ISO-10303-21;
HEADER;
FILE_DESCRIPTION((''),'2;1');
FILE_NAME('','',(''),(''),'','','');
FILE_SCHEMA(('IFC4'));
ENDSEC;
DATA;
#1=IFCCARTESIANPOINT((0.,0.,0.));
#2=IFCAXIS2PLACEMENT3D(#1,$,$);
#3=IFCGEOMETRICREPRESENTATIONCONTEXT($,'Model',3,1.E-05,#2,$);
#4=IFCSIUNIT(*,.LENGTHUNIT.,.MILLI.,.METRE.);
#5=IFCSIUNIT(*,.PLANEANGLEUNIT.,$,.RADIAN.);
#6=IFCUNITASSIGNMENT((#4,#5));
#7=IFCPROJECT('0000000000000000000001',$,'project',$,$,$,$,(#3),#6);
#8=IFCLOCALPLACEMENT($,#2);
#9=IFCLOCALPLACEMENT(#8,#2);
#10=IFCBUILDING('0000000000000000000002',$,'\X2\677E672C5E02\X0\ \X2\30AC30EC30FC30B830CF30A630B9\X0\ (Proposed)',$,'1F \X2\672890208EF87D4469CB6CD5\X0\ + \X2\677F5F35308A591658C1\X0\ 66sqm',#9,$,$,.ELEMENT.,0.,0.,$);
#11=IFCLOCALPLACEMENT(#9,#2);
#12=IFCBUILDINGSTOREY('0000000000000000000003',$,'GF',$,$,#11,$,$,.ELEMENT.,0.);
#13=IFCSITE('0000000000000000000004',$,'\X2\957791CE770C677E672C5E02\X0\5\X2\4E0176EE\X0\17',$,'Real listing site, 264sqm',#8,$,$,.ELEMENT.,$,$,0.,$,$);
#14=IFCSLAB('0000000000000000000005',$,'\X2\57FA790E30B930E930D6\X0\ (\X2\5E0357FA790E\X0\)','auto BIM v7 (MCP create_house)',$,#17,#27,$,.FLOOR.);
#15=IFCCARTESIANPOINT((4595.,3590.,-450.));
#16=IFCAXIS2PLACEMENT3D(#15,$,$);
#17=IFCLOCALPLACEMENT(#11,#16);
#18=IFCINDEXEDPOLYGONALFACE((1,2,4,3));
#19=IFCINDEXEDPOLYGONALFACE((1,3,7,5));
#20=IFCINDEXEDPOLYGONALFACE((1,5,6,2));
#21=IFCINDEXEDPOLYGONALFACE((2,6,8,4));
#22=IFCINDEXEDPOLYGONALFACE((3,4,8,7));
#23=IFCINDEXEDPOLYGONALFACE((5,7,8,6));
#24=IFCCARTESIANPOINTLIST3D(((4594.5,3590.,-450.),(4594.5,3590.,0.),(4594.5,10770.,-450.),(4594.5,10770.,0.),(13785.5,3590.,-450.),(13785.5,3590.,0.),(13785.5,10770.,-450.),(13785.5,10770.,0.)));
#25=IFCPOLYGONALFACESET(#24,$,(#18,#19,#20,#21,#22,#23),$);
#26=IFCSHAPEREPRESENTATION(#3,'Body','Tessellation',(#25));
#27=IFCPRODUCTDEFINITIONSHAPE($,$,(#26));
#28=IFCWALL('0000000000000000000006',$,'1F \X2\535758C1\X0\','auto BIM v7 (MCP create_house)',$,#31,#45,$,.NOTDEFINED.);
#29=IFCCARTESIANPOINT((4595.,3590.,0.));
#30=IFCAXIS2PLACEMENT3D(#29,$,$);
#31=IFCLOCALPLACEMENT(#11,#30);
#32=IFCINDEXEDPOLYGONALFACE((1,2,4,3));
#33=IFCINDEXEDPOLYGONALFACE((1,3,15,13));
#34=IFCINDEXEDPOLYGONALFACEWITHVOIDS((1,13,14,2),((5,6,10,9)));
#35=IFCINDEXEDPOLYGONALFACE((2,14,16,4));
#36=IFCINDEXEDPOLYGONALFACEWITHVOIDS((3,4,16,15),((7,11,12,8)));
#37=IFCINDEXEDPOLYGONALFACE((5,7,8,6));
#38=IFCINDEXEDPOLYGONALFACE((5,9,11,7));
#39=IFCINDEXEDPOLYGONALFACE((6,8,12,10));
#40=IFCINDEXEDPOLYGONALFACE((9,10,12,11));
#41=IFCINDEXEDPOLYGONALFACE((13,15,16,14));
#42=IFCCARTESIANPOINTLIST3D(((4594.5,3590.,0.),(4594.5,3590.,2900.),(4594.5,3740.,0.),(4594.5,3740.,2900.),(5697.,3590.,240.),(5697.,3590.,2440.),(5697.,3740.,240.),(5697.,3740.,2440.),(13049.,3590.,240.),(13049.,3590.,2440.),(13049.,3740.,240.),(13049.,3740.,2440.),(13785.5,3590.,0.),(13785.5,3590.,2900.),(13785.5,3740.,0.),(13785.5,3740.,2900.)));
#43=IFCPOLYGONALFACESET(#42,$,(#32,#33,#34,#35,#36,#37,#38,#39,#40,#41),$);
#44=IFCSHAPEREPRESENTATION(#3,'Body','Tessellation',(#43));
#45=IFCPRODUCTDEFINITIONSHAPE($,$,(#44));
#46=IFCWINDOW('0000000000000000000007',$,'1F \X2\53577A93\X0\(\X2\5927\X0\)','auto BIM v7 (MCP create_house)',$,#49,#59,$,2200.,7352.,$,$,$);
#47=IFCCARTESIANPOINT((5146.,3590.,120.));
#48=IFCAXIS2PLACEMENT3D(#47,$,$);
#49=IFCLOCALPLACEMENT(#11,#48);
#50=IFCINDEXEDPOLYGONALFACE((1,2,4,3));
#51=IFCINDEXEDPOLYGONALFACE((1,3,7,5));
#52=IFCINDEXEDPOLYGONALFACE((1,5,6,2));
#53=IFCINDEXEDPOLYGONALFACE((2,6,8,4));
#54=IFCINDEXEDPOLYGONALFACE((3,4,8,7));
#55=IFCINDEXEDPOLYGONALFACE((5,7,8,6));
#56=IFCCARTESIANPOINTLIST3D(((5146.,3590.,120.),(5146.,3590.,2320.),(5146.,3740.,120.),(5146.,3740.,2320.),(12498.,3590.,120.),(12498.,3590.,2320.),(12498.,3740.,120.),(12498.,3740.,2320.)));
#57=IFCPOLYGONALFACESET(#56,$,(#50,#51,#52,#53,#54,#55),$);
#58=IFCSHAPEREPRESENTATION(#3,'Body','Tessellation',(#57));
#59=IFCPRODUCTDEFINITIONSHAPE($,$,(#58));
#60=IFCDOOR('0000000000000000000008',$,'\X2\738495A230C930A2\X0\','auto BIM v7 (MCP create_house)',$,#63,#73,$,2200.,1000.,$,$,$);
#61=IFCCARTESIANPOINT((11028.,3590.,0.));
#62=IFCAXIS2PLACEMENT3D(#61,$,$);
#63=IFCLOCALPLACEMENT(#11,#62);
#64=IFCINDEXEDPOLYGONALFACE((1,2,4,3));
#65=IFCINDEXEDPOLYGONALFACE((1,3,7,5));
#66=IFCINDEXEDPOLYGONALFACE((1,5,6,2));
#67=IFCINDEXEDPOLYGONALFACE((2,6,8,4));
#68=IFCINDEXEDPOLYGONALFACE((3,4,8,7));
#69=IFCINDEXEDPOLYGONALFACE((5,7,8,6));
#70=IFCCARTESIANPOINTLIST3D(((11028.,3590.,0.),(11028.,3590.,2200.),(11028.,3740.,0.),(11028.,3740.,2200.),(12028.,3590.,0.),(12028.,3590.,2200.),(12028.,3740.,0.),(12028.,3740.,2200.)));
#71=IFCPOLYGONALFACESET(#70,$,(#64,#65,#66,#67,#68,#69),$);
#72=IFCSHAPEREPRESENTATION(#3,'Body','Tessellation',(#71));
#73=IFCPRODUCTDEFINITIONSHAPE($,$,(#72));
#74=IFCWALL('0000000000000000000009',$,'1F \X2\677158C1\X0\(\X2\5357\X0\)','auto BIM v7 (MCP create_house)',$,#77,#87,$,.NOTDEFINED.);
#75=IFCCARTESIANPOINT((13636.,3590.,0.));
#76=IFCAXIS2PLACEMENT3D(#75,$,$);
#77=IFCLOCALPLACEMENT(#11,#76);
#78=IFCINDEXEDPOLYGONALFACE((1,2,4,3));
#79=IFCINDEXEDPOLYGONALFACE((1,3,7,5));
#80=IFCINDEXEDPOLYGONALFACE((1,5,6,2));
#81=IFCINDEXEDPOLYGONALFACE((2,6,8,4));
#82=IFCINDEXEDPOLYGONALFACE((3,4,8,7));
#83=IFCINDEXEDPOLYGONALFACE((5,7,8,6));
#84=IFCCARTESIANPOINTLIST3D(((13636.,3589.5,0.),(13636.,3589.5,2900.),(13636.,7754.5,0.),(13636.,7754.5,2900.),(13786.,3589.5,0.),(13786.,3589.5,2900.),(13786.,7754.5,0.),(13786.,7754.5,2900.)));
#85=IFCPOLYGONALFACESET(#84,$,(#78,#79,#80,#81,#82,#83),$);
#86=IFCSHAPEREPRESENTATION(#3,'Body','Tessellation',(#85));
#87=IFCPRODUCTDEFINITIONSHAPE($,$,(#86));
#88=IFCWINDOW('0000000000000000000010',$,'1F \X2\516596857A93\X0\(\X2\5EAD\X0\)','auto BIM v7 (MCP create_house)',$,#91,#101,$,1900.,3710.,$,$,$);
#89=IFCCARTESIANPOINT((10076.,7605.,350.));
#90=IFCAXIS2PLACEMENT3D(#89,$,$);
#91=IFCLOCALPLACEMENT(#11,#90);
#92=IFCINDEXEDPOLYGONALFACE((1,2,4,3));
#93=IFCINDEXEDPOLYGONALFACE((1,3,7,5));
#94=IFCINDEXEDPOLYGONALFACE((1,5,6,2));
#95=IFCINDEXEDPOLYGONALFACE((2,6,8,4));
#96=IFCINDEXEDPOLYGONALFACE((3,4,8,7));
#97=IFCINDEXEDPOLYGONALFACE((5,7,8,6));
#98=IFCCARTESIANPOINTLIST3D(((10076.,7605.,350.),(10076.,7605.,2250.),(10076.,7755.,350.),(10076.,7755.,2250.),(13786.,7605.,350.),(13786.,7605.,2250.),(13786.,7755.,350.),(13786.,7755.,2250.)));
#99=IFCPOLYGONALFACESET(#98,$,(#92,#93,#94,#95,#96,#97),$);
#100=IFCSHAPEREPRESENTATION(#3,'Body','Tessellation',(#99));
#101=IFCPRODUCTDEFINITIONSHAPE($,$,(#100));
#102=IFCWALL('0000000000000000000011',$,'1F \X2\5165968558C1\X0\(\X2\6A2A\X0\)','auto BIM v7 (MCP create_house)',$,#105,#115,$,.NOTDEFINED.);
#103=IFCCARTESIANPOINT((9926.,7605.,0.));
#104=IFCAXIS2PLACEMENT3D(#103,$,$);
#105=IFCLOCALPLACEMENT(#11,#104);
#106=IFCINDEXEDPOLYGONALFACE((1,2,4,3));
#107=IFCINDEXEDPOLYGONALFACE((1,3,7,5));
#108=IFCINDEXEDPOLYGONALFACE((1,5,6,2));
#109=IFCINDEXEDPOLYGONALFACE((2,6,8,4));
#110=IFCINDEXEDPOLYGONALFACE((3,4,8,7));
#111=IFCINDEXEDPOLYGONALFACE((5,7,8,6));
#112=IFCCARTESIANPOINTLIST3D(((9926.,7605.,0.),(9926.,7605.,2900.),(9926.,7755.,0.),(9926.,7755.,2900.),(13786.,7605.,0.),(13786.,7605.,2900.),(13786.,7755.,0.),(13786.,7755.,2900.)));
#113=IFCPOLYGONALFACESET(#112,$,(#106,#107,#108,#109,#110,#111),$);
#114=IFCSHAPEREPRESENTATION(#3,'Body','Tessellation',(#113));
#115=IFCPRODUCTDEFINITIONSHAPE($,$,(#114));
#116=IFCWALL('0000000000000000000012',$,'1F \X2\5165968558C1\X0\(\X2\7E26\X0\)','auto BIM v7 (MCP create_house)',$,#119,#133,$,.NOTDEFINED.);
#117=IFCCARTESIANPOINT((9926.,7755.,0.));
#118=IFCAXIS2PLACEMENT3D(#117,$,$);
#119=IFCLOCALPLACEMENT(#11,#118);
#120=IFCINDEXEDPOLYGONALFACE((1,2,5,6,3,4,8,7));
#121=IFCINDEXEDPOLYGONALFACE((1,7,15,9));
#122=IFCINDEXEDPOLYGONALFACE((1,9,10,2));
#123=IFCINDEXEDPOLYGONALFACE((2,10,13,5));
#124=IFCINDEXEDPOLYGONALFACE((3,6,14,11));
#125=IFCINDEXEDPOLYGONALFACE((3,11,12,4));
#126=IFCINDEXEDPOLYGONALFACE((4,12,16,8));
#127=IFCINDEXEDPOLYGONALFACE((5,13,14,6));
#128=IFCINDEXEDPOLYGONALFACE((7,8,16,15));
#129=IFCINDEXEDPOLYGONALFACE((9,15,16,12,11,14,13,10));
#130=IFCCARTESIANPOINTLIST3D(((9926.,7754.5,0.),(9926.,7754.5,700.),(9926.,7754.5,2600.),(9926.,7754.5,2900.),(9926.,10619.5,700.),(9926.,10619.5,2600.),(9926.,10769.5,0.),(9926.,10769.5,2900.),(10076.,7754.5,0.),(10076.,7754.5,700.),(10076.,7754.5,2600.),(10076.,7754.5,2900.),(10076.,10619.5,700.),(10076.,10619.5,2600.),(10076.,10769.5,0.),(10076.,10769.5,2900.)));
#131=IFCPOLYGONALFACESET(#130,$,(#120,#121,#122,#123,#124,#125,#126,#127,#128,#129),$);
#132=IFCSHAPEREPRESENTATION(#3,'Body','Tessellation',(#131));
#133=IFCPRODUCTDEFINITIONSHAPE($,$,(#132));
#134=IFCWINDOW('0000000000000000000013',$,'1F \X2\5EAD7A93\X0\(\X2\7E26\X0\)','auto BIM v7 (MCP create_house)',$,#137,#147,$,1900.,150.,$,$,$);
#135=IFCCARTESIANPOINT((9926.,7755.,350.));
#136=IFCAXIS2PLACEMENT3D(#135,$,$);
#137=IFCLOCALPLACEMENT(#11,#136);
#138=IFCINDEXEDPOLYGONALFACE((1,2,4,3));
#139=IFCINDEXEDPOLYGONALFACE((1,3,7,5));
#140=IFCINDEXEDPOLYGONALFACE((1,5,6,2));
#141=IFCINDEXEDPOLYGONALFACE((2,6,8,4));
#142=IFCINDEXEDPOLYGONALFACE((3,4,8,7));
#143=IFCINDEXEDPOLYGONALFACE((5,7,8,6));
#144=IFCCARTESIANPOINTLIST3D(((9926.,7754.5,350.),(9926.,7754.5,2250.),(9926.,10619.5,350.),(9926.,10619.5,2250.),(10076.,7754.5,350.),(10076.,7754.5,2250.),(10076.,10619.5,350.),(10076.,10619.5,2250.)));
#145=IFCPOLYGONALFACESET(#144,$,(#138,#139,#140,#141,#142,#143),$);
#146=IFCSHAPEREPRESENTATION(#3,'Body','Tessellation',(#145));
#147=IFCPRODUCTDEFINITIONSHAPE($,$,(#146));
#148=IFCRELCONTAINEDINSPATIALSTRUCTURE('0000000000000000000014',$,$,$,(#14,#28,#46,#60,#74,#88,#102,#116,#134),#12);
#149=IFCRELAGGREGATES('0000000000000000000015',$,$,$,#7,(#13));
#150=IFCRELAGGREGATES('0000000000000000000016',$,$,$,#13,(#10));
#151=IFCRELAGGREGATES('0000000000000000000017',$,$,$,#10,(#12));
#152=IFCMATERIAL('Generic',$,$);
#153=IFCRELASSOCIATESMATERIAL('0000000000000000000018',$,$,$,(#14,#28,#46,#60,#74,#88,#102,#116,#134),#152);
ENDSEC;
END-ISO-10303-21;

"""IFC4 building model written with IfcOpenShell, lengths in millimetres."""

from ifc_helpers import new_model, si_unit, frame, frame_2d, origin, place, context, project, spatial, rectangle, extrude, material, element, fill, save


model = new_model("IFC4")

# Units and contexts
model_context = context("Model", 3, precision=1e-05, world=origin())
ifc_project = project(units=[si_unit("LENGTHUNIT", "METRE", prefix="MILLI"), si_unit("PLANEANGLEUNIT", "RADIAN")], contexts=[model_context])

# Site, building, storey
site_placement = place(None, origin())
site = spatial("IfcSite", under=ifc_project, at=site_placement, Name="長野県松本市5丁目17", ObjectType="Real listing site, 264sqm", CompositionType="ELEMENT", RefElevation=0.0)
building_placement = place(site_placement, origin())
building = spatial("IfcBuilding", under=site, at=building_placement, Name="松本市 ガレージハウス (Proposed)", ObjectType="1F 木造軸組構法 + 板張り外壁 66sqm", CompositionType="ELEMENT", ElevationOfRefHeight=0.0, ElevationOfTerrain=0.0)
storey_placement = place(building_placement, origin())
storey = spatial("IfcBuildingStorey", under=building, at=storey_placement, Name="GF", CompositionType="ELEMENT", Elevation=0.0)

# Slab
ifc_material = material(Name="Generic")
slab_1_placement = place(storey_placement, frame((4595.0, 3590.0, -450.0)))
element("IfcSlab", 1, at=slab_1_placement, inside=storey, material=ifc_material, Name="基礎スラブ (布基礎)", Description="auto BIM v7 (MCP create_house)", PredefinedType="FLOOR", context=model_context, shape_type="SweptSolid", body=[
    extrude(rectangle(XDim=9191.0, YDim=7180.0, at=frame_2d((4595.0, 3590.0))), frame((4595.0, 3590.0, -450.0)), (0.0, 0.0, 1.0), 450.0),
])

# Wall, openings, window, door
wall_1_placement = place(storey_placement, frame((4595.0, 3590.0, 0.0)))
wall_1 = element("IfcWall", 2, at=wall_1_placement, inside=storey, material=ifc_material, Name="1F 南壁", Description="auto BIM v7 (MCP create_house)", PredefinedType="NOTDEFINED", context=model_context, shape_type="SweptSolid", body=[
    extrude(rectangle(XDim=9191.0, YDim=150.0, at=frame_2d((4595.0, 75.0))), frame((4595.0, 3590.0, 0.0)), (0.0, 0.0, 1.0), 2900.0),
])
opening_1_placement = place(storey_placement, frame((5146.0, 3590.0, 120.0)))
opening_1 = element("IfcOpeningElement", 3, at=opening_1_placement, cuts=wall_1, PredefinedType="NOTDEFINED", context=model_context, shape_type="SweptSolid", body=[
    extrude(rectangle(XDim=7352.0, YDim=150.0, at=frame_2d((3676.0, 75.0))), frame((5146.0, 3590.0, 120.0)), (0.0, 0.0, 1.0), 2200.0),
])
opening_2_placement = place(storey_placement, frame((11028.0, 3590.0, 0.0)))
opening_2 = element("IfcOpeningElement", 4, at=opening_2_placement, cuts=wall_1, PredefinedType="NOTDEFINED", context=model_context, shape_type="SweptSolid", body=[
    extrude(rectangle(XDim=1000.0, YDim=150.0, at=frame_2d((500.0, 75.0))), frame((11028.0, 3590.0, 0.0)), (0.0, 0.0, 1.0), 2200.0),
])
window_1_placement = place(storey_placement, frame((5146.0, 3590.0, 120.0)))
window_1 = element("IfcWindow", 5, at=window_1_placement, inside=storey, material=ifc_material, Name="1F 南窓(大)", Description="auto BIM v7 (MCP create_house)", OverallHeight=2200.0, OverallWidth=7352.0, context=model_context, shape_type="SweptSolid", body=[
    extrude(rectangle(XDim=7352.0, YDim=150.0, at=frame_2d((3676.0, 75.0))), frame((5146.0, 3590.0, 120.0)), (0.0, 0.0, 1.0), 2200.0),
])
fill(opening_1, window_1)
door_placement = place(storey_placement, frame((11028.0, 3590.0, 0.0)))
door = element("IfcDoor", 6, at=door_placement, inside=storey, material=ifc_material, Name="玄関ドア", Description="auto BIM v7 (MCP create_house)", OverallHeight=2200.0, OverallWidth=1000.0, context=model_context, shape_type="SweptSolid", body=[
    extrude(rectangle(XDim=1000.0, YDim=150.0, at=frame_2d((500.0, 75.0))), frame((11028.0, 3590.0, 0.0)), (0.0, 0.0, 1.0), 2200.0),
])
fill(opening_2, door)

# Wall, opening, window
wall_2_placement = place(storey_placement, frame((13636.0, 3590.0, 0.0)))
wall_2 = element("IfcWall", 7, at=wall_2_placement, inside=storey, material=ifc_material, Name="1F 東壁(南)", Description="auto BIM v7 (MCP create_house)", PredefinedType="NOTDEFINED", context=model_context, shape_type="SweptSolid", body=[
    extrude(rectangle(XDim=150.0, YDim=4165.0, at=frame_2d((75.0, 2082.0))), frame((13636.0, 3590.0, 0.0)), (0.0, 0.0, 1.0), 2900.0),
])
opening_3_placement = place(storey_placement, frame((10076.0, 7605.0, 350.0)))
opening_3 = element("IfcOpeningElement", 8, at=opening_3_placement, cuts=wall_2, PredefinedType="NOTDEFINED", context=model_context, shape_type="SweptSolid", body=[
    extrude(rectangle(XDim=3710.0, YDim=150.0, at=frame_2d((1855.0, 75.0))), frame((10076.0, 7605.0, 350.0)), (0.0, 0.0, 1.0), 1900.0),
])
window_2_placement = place(storey_placement, frame((10076.0, 7605.0, 350.0)))
window_2 = element("IfcWindow", 9, at=window_2_placement, inside=storey, material=ifc_material, Name="1F 入隅窓(庭)", Description="auto BIM v7 (MCP create_house)", OverallHeight=1900.0, OverallWidth=3710.0, context=model_context, shape_type="SweptSolid", body=[
    extrude(rectangle(XDim=3710.0, YDim=150.0, at=frame_2d((1855.0, 75.0))), frame((10076.0, 7605.0, 350.0)), (0.0, 0.0, 1.0), 1900.0),
])
fill(opening_3, window_2)

# Wall
wall_3_placement = place(storey_placement, frame((9926.0, 7605.0, 0.0)))
element("IfcWall", 10, at=wall_3_placement, inside=storey, material=ifc_material, Name="1F 入隅壁(横)", Description="auto BIM v7 (MCP create_house)", PredefinedType="NOTDEFINED", context=model_context, shape_type="SweptSolid", body=[
    extrude(rectangle(XDim=3860.0, YDim=150.0, at=frame_2d((1930.0, 75.0))), frame((9926.0, 7605.0, 0.0)), (0.0, 0.0, 1.0), 2900.0),
])

# Wall, opening, window
wall_4_placement = place(storey_placement, frame((9926.0, 7755.0, 0.0)))
wall_4 = element("IfcWall", 11, at=wall_4_placement, inside=storey, material=ifc_material, Name="1F 入隅壁(縦)", Description="auto BIM v7 (MCP create_house)", PredefinedType="NOTDEFINED", context=model_context, shape_type="SweptSolid", body=[
    extrude(rectangle(XDim=150.0, YDim=3015.0, at=frame_2d((75.0, 1507.0))), frame((9926.0, 7755.0, 0.0)), (0.0, 0.0, 1.0), 2900.0),
])
opening_4_placement = place(storey_placement, frame((9926.0, 7755.0, 350.0)))
opening_4 = element("IfcOpeningElement", 12, at=opening_4_placement, cuts=wall_4, PredefinedType="NOTDEFINED", context=model_context, shape_type="SweptSolid", body=[
    extrude(rectangle(XDim=150.0, YDim=2865.0, at=frame_2d((75.0, 1432.0))), frame((9926.0, 7755.0, 350.0)), (0.0, 0.0, 1.0), 1900.0),
])
window_3_placement = place(storey_placement, frame((9926.0, 7755.0, 350.0)))
window_3 = element("IfcWindow", 13, at=window_3_placement, inside=storey, material=ifc_material, Name="1F 庭窓(縦)", Description="auto BIM v7 (MCP create_house)", OverallHeight=1900.0, OverallWidth=150.0, context=model_context, shape_type="SweptSolid", body=[
    extrude(rectangle(XDim=150.0, YDim=2865.0, at=frame_2d((75.0, 1432.0))), frame((9926.0, 7755.0, 350.0)), (0.0, 0.0, 1.0), 1900.0),
])
fill(opening_4, window_3)

save(model, "model.ifc")
